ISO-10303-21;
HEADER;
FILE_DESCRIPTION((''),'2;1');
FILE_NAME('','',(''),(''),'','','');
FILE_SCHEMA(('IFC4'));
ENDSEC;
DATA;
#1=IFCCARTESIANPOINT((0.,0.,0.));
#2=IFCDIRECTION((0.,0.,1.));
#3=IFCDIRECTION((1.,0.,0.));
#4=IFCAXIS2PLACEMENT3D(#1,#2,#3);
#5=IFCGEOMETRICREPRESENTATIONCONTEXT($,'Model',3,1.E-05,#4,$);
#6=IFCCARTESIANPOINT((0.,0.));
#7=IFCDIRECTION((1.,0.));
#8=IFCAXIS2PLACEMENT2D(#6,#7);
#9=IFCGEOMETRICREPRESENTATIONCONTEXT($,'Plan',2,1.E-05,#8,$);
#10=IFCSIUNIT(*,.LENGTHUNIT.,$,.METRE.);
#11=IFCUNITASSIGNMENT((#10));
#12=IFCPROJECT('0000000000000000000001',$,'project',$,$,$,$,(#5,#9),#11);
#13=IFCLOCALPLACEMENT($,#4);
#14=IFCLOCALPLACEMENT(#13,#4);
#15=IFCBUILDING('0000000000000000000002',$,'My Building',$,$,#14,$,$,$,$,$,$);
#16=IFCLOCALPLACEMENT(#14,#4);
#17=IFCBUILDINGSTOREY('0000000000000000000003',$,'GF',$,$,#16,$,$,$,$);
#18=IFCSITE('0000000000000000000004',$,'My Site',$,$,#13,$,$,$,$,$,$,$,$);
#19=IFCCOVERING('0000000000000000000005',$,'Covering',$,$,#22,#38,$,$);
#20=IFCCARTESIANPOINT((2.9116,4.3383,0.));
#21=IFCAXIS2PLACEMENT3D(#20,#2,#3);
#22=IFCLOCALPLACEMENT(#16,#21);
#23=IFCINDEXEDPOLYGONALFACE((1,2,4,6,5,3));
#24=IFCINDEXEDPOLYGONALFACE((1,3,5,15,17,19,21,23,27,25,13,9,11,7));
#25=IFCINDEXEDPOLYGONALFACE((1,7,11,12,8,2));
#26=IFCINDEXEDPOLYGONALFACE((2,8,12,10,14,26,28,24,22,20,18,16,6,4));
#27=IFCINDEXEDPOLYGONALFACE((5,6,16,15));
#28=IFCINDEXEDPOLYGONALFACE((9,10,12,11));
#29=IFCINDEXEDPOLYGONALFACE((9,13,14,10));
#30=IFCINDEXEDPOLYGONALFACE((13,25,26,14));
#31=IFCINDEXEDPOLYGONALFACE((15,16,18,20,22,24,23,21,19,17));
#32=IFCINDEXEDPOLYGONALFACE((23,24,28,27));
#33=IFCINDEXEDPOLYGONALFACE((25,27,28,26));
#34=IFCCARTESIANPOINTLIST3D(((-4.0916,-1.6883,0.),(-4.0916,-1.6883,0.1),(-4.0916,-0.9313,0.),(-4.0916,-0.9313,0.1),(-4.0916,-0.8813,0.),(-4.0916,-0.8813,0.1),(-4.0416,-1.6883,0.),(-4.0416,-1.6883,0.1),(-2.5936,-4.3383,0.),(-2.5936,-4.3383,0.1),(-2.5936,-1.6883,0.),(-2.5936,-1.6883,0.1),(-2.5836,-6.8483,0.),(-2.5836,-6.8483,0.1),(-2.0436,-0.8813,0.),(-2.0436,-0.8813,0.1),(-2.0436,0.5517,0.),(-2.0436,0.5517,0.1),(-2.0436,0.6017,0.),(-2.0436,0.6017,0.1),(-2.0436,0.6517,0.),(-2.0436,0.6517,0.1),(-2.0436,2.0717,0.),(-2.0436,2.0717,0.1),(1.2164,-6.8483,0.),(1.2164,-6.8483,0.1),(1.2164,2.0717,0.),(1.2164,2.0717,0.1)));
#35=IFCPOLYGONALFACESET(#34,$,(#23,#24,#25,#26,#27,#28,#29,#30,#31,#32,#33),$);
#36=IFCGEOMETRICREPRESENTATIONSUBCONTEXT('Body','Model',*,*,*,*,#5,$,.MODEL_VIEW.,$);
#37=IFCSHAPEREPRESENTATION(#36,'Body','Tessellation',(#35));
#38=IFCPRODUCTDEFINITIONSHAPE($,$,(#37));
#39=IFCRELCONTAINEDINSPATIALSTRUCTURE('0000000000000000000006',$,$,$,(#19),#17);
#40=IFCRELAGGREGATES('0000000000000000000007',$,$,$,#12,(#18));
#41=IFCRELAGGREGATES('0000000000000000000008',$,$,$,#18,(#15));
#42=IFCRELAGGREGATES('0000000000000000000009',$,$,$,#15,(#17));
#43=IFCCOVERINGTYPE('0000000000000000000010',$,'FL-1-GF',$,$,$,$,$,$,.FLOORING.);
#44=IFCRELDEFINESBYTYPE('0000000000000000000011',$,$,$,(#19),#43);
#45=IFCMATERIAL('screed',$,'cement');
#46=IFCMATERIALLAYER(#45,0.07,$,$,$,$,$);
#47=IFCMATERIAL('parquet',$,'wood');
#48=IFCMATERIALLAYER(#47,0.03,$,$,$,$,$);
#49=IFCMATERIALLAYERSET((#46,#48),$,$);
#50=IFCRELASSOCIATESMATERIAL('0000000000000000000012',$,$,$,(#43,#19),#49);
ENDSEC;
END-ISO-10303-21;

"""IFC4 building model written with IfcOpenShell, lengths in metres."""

from ifc_helpers import new_model, si_unit, frame, origin_with_axes, origin_2d_with_axis, place, context, subcontext, project, spatial, line, indexed_curve, outline, extrude, material, layer, layer_set, layer_usage, type_object, element, save


model = new_model("IFC4")

# Units and contexts
model_context = context("Model", 3, precision=1e-05, world=origin_with_axes())
plan_context = context("Plan", 2, precision=1e-05, world=origin_2d_with_axis())
body_context_1 = subcontext(model_context, "Body", "Model", "MODEL_VIEW")
ifc_project = project(units=[si_unit("LENGTHUNIT", "METRE")], contexts=[model_context, plan_context])

# Site, building, storey
site_placement = place(None, origin_with_axes())
site = spatial("IfcSite", under=ifc_project, at=site_placement, Name="My Site")
building_placement = place(site_placement, origin_with_axes())
building = spatial("IfcBuilding", under=site, at=building_placement, Name="My Building")
storey_placement = place(building_placement, origin_with_axes())
storey = spatial("IfcBuildingStorey", under=building, at=storey_placement, Name="GF")

# Covering
ifc_material_1 = material(Name="screed", Category="cement")
ifc_layer_1 = layer(ifc_material_1, 0.07)
ifc_material_2 = material(Name="parquet", Category="wood")
ifc_layer_2 = layer(ifc_material_2, 0.03)
ifc_layer_set_1 = layer_set([ifc_layer_1, ifc_layer_2])
ifc_layer_usage_1 = layer_usage(ifc_layer_set_1, "AXIS3", "POSITIVE", 0.0)
covering_type = type_object("IfcCoveringType", Name="FL-1-GF", PredefinedType="FLOORING", material=ifc_layer_set_1)
covering_placement = place(storey_placement, frame((2.9116, 4.3383, 0.0), z_axis=(0.0, 0.0, 1.0), x_axis=(1.0, 0.0, 0.0)))
element("IfcCovering", 1, at=covering_placement, inside=storey, type_object=covering_type, material=ifc_layer_usage_1, Name="Covering", context=body_context_1, shape_type="SweptSolid", body=[
    extrude(outline(indexed_curve([(-2.0436, 2.0717), (1.2164, 2.0717), (1.2164, -6.8483), (-2.5836, -6.8483), (-2.5936, -4.3383), (-2.5936, -1.6883), (-4.0416, -1.6883), (-4.0916, -1.6883), (-4.0916, -0.9313), (-4.0916, -0.8813), (-2.0436, -0.8813), (-2.0436, 0.5517), (-2.0436, 0.6017), (-2.0436, 0.6517)], segments=[line(1, 2, 3, 4, 5, 6, 7, 8, 9, 10, 11, 12, 13, 14, 1)])), origin_with_axes(), (0.0, 0.0, 1.0), 0.1),
])

save(model, "model.ifc")
